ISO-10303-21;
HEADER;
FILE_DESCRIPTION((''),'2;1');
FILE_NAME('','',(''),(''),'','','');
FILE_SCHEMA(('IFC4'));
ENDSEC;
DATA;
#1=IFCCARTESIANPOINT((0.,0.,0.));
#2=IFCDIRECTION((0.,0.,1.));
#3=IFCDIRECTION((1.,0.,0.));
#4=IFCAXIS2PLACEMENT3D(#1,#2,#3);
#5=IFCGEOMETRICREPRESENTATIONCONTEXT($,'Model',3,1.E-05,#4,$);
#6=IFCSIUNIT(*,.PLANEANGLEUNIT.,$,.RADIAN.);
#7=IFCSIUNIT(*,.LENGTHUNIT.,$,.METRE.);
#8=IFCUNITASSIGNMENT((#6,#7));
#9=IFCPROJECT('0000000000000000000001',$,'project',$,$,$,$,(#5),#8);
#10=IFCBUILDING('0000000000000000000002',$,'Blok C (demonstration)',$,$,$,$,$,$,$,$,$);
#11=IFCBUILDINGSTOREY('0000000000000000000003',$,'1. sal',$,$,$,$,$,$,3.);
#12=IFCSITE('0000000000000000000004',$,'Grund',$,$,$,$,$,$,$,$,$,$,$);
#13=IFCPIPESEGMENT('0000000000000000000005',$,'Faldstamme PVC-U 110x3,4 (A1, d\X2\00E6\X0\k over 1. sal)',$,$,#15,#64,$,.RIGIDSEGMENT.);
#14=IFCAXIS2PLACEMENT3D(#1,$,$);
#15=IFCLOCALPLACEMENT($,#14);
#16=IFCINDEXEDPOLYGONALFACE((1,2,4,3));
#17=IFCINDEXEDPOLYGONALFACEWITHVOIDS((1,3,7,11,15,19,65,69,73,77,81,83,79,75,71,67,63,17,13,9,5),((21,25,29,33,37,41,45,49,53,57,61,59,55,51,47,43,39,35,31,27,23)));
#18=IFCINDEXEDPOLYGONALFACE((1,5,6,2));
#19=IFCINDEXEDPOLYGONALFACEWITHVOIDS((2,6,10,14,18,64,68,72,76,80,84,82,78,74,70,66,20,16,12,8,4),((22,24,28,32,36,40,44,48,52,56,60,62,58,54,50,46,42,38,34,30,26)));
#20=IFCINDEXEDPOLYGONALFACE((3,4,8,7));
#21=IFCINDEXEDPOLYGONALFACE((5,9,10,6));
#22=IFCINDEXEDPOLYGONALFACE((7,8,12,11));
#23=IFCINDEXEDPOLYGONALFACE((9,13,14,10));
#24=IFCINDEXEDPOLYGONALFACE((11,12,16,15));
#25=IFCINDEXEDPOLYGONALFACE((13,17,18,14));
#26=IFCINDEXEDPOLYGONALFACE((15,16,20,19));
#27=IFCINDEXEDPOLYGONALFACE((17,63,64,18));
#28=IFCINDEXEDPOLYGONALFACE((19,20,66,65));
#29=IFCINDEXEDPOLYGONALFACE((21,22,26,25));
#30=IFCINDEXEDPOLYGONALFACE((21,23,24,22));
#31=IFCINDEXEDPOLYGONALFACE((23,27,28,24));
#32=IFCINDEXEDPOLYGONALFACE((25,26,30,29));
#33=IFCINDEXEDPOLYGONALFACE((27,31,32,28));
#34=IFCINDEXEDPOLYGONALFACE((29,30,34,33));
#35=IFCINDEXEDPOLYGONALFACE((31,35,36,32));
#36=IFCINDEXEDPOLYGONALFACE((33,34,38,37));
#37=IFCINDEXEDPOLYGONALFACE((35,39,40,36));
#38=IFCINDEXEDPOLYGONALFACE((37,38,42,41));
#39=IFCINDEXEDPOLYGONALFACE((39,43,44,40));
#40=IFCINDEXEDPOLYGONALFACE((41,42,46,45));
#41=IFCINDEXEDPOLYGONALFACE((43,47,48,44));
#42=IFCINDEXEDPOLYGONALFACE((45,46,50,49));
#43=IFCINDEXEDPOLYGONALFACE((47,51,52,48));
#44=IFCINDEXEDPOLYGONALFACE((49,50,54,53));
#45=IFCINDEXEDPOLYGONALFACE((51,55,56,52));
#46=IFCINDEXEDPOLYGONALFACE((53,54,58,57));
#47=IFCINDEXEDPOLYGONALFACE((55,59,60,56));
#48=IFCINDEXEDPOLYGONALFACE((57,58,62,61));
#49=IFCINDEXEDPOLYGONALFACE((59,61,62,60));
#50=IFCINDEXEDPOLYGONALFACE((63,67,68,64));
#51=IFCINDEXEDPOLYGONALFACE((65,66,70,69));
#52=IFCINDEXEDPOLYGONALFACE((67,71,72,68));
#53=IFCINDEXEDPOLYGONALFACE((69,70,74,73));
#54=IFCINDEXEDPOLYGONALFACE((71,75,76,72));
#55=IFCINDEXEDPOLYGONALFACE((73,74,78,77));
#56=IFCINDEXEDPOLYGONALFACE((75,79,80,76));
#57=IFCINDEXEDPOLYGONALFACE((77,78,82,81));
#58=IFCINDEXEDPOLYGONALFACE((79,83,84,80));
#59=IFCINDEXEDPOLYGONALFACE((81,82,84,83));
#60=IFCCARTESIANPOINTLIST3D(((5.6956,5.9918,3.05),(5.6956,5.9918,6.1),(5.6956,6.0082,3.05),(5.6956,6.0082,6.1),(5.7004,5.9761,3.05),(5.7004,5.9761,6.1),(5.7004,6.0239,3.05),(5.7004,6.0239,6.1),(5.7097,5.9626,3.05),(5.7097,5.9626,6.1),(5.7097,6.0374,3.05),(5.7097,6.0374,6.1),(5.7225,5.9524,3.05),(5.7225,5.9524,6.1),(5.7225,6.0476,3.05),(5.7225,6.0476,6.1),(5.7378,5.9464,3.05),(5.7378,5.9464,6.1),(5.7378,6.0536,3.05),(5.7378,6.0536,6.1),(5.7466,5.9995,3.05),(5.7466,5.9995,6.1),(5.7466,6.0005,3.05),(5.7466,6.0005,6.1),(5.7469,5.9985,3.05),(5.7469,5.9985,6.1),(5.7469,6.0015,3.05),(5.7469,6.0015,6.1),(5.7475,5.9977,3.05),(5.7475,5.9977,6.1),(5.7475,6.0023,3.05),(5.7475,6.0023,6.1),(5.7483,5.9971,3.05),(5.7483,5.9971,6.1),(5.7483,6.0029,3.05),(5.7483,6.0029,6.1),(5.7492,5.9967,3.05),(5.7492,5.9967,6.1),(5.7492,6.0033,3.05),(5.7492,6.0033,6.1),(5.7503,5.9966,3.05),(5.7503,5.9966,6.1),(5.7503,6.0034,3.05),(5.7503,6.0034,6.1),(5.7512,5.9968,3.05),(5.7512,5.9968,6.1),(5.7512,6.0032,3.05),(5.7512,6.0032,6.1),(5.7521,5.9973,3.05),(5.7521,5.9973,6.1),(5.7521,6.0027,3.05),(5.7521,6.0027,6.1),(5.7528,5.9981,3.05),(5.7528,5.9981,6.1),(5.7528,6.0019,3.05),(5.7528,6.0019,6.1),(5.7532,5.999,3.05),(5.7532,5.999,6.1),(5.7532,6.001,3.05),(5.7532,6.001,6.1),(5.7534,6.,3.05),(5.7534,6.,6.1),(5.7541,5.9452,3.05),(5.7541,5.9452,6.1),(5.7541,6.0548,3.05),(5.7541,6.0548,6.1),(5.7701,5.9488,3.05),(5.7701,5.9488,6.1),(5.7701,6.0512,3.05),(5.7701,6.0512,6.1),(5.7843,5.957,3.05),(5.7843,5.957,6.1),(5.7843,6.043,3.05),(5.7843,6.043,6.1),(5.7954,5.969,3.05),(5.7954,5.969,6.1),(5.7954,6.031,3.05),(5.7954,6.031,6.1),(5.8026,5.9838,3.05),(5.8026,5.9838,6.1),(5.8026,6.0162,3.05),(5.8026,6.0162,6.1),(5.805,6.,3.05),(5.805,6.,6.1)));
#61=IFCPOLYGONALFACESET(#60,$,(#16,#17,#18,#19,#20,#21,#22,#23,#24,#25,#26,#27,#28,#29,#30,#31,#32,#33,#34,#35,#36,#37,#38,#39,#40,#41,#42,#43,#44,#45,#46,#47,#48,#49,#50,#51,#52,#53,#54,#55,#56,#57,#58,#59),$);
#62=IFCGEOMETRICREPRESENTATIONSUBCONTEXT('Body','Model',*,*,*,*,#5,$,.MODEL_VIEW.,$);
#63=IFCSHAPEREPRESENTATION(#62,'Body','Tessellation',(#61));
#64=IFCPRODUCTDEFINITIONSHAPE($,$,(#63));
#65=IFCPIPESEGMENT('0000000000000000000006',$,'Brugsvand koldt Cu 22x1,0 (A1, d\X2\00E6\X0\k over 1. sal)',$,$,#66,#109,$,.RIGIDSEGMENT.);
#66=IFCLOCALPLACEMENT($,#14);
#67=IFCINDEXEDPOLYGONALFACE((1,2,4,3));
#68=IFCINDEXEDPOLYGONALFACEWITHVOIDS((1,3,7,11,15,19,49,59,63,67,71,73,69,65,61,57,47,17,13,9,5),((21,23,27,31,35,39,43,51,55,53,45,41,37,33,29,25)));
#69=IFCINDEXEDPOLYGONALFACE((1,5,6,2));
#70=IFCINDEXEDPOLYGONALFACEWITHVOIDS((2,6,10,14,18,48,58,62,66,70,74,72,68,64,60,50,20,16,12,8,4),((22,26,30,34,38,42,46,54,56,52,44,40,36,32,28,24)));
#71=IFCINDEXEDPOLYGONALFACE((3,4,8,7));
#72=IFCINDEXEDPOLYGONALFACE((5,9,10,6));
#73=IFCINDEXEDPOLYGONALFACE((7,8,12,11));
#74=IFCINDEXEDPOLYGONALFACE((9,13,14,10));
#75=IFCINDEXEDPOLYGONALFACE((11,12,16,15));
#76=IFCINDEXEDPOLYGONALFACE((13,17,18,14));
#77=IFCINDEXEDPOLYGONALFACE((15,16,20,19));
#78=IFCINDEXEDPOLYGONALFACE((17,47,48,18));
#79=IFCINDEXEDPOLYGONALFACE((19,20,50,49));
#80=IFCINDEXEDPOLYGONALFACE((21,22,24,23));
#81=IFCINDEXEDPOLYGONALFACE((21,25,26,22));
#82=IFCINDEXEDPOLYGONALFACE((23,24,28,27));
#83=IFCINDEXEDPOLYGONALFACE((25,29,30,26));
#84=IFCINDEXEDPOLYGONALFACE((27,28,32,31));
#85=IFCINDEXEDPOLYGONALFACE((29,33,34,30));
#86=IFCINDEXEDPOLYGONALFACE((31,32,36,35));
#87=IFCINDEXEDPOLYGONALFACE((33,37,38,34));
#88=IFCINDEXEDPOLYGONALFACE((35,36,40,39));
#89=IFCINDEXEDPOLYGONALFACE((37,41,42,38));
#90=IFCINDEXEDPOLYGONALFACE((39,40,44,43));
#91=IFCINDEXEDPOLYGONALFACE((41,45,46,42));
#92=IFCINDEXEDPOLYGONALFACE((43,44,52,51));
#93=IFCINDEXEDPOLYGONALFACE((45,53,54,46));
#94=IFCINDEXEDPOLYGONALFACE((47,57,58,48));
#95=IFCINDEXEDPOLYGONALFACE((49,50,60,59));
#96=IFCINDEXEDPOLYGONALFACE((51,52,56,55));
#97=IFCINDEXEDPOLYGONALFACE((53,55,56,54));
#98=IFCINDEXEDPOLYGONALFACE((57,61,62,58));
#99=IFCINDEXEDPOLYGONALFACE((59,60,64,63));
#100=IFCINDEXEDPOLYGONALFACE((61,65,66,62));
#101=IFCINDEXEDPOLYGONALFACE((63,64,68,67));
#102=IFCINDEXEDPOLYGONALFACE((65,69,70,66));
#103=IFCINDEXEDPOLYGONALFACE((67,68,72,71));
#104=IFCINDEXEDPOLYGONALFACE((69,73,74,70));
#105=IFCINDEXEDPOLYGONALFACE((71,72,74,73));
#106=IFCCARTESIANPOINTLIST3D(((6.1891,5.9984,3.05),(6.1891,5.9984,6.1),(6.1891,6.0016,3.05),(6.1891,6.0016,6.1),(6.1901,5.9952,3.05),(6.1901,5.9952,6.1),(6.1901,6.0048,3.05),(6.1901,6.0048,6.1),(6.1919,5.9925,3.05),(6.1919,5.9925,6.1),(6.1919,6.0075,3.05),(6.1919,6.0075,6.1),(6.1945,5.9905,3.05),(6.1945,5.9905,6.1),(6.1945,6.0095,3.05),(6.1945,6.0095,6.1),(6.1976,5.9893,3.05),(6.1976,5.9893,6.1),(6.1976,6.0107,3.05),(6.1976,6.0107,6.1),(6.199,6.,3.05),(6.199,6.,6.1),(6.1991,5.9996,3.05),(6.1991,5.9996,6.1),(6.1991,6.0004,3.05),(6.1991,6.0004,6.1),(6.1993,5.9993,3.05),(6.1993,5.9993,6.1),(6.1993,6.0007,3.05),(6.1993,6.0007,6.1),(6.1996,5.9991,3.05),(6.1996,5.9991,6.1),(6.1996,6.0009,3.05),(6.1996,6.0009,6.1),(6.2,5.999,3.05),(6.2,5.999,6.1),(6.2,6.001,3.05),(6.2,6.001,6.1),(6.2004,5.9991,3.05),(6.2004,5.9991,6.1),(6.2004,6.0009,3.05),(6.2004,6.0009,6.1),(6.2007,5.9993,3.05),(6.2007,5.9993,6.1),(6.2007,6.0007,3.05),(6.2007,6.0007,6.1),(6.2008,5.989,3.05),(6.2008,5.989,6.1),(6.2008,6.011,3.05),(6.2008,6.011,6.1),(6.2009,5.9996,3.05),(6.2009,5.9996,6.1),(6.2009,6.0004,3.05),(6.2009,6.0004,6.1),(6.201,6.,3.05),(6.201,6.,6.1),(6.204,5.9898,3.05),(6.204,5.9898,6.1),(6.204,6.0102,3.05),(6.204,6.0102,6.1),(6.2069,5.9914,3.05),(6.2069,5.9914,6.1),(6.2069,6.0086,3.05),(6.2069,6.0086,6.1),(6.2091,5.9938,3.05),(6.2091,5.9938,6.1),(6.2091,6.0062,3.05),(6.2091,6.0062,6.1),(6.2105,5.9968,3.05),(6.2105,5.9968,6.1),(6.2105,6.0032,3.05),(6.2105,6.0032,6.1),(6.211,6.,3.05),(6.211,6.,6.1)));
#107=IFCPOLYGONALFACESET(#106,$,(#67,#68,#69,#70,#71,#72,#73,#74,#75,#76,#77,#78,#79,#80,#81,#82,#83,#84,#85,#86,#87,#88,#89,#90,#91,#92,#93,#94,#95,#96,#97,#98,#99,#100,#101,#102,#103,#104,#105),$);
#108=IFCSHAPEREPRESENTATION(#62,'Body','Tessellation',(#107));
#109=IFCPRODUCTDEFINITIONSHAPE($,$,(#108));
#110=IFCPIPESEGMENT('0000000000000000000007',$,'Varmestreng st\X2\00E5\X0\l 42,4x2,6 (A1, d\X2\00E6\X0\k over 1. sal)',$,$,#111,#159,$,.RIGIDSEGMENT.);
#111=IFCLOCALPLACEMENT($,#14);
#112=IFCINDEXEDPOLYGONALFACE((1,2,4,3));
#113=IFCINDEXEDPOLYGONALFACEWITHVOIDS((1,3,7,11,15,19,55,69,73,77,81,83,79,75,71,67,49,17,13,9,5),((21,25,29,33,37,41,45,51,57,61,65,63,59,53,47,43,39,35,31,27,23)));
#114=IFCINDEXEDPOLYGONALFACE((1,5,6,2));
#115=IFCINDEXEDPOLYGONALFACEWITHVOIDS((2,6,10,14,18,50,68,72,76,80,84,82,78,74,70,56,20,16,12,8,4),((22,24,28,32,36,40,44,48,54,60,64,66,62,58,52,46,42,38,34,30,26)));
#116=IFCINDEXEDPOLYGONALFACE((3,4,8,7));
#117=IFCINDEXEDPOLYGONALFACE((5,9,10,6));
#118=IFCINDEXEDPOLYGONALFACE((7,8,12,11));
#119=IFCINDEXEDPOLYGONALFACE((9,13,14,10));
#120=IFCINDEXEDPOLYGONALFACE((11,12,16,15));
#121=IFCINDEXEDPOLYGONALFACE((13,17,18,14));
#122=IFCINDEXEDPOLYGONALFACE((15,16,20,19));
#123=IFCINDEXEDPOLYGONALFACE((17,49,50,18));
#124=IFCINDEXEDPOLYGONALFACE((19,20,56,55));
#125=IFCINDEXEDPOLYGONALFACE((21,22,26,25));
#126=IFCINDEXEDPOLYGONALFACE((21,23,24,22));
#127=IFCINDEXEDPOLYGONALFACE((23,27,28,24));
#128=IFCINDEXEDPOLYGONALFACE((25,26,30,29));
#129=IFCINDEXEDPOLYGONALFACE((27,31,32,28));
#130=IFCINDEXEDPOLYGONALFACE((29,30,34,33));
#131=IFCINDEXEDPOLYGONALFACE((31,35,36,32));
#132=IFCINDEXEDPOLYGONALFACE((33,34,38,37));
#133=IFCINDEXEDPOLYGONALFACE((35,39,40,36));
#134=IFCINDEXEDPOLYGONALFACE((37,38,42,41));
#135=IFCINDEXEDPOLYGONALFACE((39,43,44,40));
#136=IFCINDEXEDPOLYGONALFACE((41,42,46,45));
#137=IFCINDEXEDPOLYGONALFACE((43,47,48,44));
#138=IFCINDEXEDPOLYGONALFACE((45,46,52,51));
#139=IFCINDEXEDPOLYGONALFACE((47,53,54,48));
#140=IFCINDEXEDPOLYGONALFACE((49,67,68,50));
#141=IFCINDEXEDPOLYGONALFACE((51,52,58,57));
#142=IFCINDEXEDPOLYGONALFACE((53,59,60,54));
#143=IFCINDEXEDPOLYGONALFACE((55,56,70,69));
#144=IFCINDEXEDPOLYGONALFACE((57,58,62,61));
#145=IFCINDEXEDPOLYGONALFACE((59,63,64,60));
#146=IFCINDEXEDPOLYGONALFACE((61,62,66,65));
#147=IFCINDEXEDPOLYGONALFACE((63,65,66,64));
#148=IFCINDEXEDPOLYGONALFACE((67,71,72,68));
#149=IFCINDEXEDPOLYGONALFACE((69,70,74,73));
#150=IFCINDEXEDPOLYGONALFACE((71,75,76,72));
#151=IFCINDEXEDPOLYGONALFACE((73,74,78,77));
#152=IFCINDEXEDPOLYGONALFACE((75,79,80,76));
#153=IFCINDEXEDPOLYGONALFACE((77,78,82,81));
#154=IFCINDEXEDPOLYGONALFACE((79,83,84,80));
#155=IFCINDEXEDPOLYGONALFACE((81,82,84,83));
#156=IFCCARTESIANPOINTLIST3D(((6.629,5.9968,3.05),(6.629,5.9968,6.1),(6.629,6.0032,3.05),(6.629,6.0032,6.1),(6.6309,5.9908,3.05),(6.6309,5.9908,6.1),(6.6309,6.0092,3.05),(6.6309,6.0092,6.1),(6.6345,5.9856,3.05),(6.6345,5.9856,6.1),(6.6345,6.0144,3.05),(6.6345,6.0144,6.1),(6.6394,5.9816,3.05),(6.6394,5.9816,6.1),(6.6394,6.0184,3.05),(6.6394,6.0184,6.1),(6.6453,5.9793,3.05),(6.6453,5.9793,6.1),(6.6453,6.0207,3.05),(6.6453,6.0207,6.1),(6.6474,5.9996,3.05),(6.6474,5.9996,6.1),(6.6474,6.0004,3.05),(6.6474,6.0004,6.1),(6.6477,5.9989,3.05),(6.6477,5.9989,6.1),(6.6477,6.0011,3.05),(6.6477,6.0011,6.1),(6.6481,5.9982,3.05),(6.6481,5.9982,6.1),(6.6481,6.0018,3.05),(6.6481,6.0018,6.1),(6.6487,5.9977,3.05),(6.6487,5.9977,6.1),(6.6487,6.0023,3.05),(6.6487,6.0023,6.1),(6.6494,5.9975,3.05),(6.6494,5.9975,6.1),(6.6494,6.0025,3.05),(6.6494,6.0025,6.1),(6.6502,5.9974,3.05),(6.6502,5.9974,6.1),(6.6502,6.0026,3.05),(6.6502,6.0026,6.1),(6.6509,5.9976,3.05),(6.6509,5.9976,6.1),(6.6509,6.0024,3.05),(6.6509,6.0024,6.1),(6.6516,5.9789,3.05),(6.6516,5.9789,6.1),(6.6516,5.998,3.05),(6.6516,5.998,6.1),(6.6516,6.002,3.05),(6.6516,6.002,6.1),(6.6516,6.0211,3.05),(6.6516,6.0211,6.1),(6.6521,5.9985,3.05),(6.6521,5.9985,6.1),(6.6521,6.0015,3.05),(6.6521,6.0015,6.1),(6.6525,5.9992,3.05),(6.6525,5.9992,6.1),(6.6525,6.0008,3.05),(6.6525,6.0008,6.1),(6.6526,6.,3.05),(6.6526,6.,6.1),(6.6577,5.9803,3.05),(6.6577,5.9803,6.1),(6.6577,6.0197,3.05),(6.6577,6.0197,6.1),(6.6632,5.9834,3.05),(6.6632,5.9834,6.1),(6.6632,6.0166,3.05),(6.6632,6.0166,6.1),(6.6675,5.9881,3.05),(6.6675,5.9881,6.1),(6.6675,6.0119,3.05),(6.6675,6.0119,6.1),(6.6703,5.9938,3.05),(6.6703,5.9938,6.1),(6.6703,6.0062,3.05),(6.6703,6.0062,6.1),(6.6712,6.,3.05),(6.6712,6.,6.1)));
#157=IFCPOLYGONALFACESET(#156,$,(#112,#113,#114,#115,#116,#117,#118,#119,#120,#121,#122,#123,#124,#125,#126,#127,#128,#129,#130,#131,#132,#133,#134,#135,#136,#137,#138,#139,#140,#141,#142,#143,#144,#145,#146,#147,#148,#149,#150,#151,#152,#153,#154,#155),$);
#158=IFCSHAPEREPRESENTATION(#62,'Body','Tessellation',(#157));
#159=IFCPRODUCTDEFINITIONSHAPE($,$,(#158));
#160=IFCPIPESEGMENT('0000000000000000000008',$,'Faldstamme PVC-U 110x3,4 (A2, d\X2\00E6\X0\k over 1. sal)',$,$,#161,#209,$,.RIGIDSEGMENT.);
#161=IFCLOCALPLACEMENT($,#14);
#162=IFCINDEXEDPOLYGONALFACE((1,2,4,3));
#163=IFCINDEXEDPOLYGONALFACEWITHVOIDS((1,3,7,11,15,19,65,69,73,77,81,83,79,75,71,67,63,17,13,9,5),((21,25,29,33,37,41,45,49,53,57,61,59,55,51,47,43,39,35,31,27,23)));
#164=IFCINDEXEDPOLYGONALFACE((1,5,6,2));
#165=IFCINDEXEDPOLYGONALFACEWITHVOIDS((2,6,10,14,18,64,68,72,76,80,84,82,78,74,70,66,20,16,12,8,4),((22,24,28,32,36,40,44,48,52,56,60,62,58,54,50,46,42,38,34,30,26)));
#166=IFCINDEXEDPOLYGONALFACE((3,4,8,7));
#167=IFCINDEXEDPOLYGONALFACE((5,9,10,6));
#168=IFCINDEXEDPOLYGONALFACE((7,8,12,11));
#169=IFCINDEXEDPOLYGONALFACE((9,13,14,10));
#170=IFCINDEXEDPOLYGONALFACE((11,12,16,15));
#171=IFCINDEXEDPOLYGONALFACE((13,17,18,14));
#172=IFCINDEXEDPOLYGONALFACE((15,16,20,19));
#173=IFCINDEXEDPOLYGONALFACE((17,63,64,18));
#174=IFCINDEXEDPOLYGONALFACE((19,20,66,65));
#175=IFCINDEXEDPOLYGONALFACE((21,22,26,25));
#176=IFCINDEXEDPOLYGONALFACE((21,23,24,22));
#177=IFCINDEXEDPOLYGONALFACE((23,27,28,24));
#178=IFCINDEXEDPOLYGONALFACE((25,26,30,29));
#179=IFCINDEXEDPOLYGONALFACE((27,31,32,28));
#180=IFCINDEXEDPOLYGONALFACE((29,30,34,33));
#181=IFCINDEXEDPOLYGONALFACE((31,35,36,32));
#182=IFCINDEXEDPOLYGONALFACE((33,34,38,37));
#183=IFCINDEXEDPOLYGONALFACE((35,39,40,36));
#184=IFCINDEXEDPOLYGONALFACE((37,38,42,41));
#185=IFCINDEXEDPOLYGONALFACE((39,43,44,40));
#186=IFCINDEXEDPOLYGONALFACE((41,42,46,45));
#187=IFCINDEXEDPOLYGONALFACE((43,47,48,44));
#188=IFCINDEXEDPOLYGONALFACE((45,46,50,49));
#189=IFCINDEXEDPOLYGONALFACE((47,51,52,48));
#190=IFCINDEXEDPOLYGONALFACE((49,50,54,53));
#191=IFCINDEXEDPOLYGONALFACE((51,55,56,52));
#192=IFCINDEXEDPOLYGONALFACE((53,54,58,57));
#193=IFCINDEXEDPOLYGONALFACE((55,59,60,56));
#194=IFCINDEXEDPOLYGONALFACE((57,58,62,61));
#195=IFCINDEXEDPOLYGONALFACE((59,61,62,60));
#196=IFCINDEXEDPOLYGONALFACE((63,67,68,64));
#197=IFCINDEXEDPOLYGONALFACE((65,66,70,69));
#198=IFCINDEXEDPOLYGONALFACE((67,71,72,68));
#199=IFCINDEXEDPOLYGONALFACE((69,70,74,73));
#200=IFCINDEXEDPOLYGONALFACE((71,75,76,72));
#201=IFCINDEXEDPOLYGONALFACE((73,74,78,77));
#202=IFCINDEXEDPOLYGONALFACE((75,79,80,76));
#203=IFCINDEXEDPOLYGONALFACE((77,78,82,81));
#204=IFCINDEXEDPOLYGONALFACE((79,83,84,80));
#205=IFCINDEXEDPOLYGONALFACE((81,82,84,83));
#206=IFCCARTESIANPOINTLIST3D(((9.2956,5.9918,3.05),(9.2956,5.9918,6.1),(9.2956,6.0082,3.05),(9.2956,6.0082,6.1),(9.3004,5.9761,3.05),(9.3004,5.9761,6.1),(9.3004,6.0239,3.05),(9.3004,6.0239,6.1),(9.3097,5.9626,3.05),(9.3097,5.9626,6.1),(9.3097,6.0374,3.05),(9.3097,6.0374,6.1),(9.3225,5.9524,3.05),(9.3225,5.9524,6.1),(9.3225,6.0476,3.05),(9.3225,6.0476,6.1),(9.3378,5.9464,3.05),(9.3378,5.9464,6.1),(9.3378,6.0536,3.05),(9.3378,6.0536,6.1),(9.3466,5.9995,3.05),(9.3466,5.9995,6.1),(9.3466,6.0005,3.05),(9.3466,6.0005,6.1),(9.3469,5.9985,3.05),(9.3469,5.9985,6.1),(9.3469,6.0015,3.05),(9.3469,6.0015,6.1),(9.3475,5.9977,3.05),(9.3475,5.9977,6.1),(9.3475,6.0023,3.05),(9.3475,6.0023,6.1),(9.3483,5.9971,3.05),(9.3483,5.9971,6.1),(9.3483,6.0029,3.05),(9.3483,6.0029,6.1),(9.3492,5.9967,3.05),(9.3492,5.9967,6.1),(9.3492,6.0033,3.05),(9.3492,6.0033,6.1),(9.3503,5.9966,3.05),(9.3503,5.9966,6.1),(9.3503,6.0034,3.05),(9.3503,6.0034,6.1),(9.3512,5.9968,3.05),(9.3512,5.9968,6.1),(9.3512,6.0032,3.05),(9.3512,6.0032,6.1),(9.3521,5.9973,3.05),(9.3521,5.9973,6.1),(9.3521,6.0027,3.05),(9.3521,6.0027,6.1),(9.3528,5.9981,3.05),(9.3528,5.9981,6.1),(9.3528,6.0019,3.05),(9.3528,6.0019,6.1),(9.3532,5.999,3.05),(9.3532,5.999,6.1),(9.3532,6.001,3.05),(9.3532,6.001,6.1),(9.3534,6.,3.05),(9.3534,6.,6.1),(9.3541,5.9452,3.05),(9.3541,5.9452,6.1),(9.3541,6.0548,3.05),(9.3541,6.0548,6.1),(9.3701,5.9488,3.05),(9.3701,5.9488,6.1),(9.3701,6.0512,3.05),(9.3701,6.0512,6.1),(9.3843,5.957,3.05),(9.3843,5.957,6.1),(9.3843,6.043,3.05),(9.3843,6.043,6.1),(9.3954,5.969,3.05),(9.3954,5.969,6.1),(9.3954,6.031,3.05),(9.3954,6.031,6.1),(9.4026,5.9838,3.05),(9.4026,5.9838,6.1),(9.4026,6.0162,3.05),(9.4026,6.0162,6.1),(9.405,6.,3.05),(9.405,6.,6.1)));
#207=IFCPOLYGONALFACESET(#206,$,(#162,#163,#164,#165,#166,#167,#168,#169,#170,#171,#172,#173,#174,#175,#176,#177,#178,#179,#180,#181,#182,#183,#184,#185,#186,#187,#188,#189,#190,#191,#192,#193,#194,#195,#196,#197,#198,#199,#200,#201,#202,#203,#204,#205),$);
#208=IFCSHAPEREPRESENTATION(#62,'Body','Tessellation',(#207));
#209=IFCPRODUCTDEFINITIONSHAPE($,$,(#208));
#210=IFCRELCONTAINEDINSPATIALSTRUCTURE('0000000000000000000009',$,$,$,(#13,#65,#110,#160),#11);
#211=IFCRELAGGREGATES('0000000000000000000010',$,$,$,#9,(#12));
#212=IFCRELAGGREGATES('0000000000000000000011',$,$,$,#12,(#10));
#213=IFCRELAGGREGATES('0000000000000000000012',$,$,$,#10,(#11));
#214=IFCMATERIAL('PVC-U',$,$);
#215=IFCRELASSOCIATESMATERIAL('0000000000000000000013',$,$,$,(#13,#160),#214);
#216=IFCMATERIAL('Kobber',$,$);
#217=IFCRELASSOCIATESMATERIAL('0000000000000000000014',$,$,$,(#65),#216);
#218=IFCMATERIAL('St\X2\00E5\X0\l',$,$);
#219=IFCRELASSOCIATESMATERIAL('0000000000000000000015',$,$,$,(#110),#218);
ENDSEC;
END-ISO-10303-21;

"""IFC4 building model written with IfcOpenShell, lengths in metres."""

from ifc_helpers import new_model, si_unit, frame, origin_with_axes, place, context, subcontext, project, spatial, hollow_circle, extrude, material, element, save


model = new_model("IFC4")

# Units and contexts
model_context = context("Model", 3, precision=1e-05, world=origin_with_axes())
body_context = subcontext(model_context, "Body", "Model", "MODEL_VIEW")
ifc_project = project(units=[si_unit("PLANEANGLEUNIT", "RADIAN"), si_unit("LENGTHUNIT", "METRE")], contexts=[model_context])

# Site, building, storey
site = spatial("IfcSite", under=ifc_project, Name="Grund")
building = spatial("IfcBuilding", under=site, Name="Blok C (demonstration)")
storey = spatial("IfcBuildingStorey", under=building, Name="1. sal", Elevation=3.0)

# Pipe segments
ifc_material_1 = material(Name="PVC-U")
pipe_segment_1_placement = place(None, origin_with_axes())
element("IfcPipeSegment", 1, at=pipe_segment_1_placement, inside=storey, material=ifc_material_1, Name="Faldstamme PVC-U 110x3,4 (A1, dæk over 1. sal)", PredefinedType="RIGIDSEGMENT", context=body_context, shape_type="SweptSolid", body=[
    extrude(hollow_circle(Radius=0.055, WallThickness=0.0516), frame((5.75, 6.0, 3.05), z_axis=(0.0, 0.0, 1.0), x_axis=(1.0, 0.0, 0.0)), (0.0, 0.0, 1.0), 3.05),
])
ifc_material_2 = material(Name="Kobber")
pipe_segment_2_placement = place(None, origin_with_axes())
element("IfcPipeSegment", 2, at=pipe_segment_2_placement, inside=storey, material=ifc_material_2, Name="Brugsvand koldt Cu 22x1,0 (A1, dæk over 1. sal)", PredefinedType="RIGIDSEGMENT", context=body_context, shape_type="SweptSolid", body=[
    extrude(hollow_circle(Radius=0.011, WallThickness=0.01), frame((6.2, 6.0, 3.05), z_axis=(0.0, 0.0, 1.0), x_axis=(1.0, 0.0, 0.0)), (0.0, 0.0, 1.0), 3.05),
])
ifc_material_3 = material(Name="Stål")
pipe_segment_3_placement = place(None, origin_with_axes())
element("IfcPipeSegment", 3, at=pipe_segment_3_placement, inside=storey, material=ifc_material_3, Name="Varmestreng stål 42,4x2,6 (A1, dæk over 1. sal)", PredefinedType="RIGIDSEGMENT", context=body_context, shape_type="SweptSolid", body=[
    extrude(hollow_circle(Radius=0.0212, WallThickness=0.0186), frame((6.65, 6.0, 3.05), z_axis=(0.0, 0.0, 1.0), x_axis=(1.0, 0.0, 0.0)), (0.0, 0.0, 1.0), 3.05),
])
pipe_segment_4_placement = place(None, origin_with_axes())
element("IfcPipeSegment", 4, at=pipe_segment_4_placement, inside=storey, material=ifc_material_1, Name="Faldstamme PVC-U 110x3,4 (A2, dæk over 1. sal)", PredefinedType="RIGIDSEGMENT", context=body_context, shape_type="SweptSolid", body=[
    extrude(hollow_circle(Radius=0.055, WallThickness=0.0516), frame((9.35, 6.0, 3.05), z_axis=(0.0, 0.0, 1.0), x_axis=(1.0, 0.0, 0.0)), (0.0, 0.0, 1.0), 3.05),
])

save(model, "model.ifc")
